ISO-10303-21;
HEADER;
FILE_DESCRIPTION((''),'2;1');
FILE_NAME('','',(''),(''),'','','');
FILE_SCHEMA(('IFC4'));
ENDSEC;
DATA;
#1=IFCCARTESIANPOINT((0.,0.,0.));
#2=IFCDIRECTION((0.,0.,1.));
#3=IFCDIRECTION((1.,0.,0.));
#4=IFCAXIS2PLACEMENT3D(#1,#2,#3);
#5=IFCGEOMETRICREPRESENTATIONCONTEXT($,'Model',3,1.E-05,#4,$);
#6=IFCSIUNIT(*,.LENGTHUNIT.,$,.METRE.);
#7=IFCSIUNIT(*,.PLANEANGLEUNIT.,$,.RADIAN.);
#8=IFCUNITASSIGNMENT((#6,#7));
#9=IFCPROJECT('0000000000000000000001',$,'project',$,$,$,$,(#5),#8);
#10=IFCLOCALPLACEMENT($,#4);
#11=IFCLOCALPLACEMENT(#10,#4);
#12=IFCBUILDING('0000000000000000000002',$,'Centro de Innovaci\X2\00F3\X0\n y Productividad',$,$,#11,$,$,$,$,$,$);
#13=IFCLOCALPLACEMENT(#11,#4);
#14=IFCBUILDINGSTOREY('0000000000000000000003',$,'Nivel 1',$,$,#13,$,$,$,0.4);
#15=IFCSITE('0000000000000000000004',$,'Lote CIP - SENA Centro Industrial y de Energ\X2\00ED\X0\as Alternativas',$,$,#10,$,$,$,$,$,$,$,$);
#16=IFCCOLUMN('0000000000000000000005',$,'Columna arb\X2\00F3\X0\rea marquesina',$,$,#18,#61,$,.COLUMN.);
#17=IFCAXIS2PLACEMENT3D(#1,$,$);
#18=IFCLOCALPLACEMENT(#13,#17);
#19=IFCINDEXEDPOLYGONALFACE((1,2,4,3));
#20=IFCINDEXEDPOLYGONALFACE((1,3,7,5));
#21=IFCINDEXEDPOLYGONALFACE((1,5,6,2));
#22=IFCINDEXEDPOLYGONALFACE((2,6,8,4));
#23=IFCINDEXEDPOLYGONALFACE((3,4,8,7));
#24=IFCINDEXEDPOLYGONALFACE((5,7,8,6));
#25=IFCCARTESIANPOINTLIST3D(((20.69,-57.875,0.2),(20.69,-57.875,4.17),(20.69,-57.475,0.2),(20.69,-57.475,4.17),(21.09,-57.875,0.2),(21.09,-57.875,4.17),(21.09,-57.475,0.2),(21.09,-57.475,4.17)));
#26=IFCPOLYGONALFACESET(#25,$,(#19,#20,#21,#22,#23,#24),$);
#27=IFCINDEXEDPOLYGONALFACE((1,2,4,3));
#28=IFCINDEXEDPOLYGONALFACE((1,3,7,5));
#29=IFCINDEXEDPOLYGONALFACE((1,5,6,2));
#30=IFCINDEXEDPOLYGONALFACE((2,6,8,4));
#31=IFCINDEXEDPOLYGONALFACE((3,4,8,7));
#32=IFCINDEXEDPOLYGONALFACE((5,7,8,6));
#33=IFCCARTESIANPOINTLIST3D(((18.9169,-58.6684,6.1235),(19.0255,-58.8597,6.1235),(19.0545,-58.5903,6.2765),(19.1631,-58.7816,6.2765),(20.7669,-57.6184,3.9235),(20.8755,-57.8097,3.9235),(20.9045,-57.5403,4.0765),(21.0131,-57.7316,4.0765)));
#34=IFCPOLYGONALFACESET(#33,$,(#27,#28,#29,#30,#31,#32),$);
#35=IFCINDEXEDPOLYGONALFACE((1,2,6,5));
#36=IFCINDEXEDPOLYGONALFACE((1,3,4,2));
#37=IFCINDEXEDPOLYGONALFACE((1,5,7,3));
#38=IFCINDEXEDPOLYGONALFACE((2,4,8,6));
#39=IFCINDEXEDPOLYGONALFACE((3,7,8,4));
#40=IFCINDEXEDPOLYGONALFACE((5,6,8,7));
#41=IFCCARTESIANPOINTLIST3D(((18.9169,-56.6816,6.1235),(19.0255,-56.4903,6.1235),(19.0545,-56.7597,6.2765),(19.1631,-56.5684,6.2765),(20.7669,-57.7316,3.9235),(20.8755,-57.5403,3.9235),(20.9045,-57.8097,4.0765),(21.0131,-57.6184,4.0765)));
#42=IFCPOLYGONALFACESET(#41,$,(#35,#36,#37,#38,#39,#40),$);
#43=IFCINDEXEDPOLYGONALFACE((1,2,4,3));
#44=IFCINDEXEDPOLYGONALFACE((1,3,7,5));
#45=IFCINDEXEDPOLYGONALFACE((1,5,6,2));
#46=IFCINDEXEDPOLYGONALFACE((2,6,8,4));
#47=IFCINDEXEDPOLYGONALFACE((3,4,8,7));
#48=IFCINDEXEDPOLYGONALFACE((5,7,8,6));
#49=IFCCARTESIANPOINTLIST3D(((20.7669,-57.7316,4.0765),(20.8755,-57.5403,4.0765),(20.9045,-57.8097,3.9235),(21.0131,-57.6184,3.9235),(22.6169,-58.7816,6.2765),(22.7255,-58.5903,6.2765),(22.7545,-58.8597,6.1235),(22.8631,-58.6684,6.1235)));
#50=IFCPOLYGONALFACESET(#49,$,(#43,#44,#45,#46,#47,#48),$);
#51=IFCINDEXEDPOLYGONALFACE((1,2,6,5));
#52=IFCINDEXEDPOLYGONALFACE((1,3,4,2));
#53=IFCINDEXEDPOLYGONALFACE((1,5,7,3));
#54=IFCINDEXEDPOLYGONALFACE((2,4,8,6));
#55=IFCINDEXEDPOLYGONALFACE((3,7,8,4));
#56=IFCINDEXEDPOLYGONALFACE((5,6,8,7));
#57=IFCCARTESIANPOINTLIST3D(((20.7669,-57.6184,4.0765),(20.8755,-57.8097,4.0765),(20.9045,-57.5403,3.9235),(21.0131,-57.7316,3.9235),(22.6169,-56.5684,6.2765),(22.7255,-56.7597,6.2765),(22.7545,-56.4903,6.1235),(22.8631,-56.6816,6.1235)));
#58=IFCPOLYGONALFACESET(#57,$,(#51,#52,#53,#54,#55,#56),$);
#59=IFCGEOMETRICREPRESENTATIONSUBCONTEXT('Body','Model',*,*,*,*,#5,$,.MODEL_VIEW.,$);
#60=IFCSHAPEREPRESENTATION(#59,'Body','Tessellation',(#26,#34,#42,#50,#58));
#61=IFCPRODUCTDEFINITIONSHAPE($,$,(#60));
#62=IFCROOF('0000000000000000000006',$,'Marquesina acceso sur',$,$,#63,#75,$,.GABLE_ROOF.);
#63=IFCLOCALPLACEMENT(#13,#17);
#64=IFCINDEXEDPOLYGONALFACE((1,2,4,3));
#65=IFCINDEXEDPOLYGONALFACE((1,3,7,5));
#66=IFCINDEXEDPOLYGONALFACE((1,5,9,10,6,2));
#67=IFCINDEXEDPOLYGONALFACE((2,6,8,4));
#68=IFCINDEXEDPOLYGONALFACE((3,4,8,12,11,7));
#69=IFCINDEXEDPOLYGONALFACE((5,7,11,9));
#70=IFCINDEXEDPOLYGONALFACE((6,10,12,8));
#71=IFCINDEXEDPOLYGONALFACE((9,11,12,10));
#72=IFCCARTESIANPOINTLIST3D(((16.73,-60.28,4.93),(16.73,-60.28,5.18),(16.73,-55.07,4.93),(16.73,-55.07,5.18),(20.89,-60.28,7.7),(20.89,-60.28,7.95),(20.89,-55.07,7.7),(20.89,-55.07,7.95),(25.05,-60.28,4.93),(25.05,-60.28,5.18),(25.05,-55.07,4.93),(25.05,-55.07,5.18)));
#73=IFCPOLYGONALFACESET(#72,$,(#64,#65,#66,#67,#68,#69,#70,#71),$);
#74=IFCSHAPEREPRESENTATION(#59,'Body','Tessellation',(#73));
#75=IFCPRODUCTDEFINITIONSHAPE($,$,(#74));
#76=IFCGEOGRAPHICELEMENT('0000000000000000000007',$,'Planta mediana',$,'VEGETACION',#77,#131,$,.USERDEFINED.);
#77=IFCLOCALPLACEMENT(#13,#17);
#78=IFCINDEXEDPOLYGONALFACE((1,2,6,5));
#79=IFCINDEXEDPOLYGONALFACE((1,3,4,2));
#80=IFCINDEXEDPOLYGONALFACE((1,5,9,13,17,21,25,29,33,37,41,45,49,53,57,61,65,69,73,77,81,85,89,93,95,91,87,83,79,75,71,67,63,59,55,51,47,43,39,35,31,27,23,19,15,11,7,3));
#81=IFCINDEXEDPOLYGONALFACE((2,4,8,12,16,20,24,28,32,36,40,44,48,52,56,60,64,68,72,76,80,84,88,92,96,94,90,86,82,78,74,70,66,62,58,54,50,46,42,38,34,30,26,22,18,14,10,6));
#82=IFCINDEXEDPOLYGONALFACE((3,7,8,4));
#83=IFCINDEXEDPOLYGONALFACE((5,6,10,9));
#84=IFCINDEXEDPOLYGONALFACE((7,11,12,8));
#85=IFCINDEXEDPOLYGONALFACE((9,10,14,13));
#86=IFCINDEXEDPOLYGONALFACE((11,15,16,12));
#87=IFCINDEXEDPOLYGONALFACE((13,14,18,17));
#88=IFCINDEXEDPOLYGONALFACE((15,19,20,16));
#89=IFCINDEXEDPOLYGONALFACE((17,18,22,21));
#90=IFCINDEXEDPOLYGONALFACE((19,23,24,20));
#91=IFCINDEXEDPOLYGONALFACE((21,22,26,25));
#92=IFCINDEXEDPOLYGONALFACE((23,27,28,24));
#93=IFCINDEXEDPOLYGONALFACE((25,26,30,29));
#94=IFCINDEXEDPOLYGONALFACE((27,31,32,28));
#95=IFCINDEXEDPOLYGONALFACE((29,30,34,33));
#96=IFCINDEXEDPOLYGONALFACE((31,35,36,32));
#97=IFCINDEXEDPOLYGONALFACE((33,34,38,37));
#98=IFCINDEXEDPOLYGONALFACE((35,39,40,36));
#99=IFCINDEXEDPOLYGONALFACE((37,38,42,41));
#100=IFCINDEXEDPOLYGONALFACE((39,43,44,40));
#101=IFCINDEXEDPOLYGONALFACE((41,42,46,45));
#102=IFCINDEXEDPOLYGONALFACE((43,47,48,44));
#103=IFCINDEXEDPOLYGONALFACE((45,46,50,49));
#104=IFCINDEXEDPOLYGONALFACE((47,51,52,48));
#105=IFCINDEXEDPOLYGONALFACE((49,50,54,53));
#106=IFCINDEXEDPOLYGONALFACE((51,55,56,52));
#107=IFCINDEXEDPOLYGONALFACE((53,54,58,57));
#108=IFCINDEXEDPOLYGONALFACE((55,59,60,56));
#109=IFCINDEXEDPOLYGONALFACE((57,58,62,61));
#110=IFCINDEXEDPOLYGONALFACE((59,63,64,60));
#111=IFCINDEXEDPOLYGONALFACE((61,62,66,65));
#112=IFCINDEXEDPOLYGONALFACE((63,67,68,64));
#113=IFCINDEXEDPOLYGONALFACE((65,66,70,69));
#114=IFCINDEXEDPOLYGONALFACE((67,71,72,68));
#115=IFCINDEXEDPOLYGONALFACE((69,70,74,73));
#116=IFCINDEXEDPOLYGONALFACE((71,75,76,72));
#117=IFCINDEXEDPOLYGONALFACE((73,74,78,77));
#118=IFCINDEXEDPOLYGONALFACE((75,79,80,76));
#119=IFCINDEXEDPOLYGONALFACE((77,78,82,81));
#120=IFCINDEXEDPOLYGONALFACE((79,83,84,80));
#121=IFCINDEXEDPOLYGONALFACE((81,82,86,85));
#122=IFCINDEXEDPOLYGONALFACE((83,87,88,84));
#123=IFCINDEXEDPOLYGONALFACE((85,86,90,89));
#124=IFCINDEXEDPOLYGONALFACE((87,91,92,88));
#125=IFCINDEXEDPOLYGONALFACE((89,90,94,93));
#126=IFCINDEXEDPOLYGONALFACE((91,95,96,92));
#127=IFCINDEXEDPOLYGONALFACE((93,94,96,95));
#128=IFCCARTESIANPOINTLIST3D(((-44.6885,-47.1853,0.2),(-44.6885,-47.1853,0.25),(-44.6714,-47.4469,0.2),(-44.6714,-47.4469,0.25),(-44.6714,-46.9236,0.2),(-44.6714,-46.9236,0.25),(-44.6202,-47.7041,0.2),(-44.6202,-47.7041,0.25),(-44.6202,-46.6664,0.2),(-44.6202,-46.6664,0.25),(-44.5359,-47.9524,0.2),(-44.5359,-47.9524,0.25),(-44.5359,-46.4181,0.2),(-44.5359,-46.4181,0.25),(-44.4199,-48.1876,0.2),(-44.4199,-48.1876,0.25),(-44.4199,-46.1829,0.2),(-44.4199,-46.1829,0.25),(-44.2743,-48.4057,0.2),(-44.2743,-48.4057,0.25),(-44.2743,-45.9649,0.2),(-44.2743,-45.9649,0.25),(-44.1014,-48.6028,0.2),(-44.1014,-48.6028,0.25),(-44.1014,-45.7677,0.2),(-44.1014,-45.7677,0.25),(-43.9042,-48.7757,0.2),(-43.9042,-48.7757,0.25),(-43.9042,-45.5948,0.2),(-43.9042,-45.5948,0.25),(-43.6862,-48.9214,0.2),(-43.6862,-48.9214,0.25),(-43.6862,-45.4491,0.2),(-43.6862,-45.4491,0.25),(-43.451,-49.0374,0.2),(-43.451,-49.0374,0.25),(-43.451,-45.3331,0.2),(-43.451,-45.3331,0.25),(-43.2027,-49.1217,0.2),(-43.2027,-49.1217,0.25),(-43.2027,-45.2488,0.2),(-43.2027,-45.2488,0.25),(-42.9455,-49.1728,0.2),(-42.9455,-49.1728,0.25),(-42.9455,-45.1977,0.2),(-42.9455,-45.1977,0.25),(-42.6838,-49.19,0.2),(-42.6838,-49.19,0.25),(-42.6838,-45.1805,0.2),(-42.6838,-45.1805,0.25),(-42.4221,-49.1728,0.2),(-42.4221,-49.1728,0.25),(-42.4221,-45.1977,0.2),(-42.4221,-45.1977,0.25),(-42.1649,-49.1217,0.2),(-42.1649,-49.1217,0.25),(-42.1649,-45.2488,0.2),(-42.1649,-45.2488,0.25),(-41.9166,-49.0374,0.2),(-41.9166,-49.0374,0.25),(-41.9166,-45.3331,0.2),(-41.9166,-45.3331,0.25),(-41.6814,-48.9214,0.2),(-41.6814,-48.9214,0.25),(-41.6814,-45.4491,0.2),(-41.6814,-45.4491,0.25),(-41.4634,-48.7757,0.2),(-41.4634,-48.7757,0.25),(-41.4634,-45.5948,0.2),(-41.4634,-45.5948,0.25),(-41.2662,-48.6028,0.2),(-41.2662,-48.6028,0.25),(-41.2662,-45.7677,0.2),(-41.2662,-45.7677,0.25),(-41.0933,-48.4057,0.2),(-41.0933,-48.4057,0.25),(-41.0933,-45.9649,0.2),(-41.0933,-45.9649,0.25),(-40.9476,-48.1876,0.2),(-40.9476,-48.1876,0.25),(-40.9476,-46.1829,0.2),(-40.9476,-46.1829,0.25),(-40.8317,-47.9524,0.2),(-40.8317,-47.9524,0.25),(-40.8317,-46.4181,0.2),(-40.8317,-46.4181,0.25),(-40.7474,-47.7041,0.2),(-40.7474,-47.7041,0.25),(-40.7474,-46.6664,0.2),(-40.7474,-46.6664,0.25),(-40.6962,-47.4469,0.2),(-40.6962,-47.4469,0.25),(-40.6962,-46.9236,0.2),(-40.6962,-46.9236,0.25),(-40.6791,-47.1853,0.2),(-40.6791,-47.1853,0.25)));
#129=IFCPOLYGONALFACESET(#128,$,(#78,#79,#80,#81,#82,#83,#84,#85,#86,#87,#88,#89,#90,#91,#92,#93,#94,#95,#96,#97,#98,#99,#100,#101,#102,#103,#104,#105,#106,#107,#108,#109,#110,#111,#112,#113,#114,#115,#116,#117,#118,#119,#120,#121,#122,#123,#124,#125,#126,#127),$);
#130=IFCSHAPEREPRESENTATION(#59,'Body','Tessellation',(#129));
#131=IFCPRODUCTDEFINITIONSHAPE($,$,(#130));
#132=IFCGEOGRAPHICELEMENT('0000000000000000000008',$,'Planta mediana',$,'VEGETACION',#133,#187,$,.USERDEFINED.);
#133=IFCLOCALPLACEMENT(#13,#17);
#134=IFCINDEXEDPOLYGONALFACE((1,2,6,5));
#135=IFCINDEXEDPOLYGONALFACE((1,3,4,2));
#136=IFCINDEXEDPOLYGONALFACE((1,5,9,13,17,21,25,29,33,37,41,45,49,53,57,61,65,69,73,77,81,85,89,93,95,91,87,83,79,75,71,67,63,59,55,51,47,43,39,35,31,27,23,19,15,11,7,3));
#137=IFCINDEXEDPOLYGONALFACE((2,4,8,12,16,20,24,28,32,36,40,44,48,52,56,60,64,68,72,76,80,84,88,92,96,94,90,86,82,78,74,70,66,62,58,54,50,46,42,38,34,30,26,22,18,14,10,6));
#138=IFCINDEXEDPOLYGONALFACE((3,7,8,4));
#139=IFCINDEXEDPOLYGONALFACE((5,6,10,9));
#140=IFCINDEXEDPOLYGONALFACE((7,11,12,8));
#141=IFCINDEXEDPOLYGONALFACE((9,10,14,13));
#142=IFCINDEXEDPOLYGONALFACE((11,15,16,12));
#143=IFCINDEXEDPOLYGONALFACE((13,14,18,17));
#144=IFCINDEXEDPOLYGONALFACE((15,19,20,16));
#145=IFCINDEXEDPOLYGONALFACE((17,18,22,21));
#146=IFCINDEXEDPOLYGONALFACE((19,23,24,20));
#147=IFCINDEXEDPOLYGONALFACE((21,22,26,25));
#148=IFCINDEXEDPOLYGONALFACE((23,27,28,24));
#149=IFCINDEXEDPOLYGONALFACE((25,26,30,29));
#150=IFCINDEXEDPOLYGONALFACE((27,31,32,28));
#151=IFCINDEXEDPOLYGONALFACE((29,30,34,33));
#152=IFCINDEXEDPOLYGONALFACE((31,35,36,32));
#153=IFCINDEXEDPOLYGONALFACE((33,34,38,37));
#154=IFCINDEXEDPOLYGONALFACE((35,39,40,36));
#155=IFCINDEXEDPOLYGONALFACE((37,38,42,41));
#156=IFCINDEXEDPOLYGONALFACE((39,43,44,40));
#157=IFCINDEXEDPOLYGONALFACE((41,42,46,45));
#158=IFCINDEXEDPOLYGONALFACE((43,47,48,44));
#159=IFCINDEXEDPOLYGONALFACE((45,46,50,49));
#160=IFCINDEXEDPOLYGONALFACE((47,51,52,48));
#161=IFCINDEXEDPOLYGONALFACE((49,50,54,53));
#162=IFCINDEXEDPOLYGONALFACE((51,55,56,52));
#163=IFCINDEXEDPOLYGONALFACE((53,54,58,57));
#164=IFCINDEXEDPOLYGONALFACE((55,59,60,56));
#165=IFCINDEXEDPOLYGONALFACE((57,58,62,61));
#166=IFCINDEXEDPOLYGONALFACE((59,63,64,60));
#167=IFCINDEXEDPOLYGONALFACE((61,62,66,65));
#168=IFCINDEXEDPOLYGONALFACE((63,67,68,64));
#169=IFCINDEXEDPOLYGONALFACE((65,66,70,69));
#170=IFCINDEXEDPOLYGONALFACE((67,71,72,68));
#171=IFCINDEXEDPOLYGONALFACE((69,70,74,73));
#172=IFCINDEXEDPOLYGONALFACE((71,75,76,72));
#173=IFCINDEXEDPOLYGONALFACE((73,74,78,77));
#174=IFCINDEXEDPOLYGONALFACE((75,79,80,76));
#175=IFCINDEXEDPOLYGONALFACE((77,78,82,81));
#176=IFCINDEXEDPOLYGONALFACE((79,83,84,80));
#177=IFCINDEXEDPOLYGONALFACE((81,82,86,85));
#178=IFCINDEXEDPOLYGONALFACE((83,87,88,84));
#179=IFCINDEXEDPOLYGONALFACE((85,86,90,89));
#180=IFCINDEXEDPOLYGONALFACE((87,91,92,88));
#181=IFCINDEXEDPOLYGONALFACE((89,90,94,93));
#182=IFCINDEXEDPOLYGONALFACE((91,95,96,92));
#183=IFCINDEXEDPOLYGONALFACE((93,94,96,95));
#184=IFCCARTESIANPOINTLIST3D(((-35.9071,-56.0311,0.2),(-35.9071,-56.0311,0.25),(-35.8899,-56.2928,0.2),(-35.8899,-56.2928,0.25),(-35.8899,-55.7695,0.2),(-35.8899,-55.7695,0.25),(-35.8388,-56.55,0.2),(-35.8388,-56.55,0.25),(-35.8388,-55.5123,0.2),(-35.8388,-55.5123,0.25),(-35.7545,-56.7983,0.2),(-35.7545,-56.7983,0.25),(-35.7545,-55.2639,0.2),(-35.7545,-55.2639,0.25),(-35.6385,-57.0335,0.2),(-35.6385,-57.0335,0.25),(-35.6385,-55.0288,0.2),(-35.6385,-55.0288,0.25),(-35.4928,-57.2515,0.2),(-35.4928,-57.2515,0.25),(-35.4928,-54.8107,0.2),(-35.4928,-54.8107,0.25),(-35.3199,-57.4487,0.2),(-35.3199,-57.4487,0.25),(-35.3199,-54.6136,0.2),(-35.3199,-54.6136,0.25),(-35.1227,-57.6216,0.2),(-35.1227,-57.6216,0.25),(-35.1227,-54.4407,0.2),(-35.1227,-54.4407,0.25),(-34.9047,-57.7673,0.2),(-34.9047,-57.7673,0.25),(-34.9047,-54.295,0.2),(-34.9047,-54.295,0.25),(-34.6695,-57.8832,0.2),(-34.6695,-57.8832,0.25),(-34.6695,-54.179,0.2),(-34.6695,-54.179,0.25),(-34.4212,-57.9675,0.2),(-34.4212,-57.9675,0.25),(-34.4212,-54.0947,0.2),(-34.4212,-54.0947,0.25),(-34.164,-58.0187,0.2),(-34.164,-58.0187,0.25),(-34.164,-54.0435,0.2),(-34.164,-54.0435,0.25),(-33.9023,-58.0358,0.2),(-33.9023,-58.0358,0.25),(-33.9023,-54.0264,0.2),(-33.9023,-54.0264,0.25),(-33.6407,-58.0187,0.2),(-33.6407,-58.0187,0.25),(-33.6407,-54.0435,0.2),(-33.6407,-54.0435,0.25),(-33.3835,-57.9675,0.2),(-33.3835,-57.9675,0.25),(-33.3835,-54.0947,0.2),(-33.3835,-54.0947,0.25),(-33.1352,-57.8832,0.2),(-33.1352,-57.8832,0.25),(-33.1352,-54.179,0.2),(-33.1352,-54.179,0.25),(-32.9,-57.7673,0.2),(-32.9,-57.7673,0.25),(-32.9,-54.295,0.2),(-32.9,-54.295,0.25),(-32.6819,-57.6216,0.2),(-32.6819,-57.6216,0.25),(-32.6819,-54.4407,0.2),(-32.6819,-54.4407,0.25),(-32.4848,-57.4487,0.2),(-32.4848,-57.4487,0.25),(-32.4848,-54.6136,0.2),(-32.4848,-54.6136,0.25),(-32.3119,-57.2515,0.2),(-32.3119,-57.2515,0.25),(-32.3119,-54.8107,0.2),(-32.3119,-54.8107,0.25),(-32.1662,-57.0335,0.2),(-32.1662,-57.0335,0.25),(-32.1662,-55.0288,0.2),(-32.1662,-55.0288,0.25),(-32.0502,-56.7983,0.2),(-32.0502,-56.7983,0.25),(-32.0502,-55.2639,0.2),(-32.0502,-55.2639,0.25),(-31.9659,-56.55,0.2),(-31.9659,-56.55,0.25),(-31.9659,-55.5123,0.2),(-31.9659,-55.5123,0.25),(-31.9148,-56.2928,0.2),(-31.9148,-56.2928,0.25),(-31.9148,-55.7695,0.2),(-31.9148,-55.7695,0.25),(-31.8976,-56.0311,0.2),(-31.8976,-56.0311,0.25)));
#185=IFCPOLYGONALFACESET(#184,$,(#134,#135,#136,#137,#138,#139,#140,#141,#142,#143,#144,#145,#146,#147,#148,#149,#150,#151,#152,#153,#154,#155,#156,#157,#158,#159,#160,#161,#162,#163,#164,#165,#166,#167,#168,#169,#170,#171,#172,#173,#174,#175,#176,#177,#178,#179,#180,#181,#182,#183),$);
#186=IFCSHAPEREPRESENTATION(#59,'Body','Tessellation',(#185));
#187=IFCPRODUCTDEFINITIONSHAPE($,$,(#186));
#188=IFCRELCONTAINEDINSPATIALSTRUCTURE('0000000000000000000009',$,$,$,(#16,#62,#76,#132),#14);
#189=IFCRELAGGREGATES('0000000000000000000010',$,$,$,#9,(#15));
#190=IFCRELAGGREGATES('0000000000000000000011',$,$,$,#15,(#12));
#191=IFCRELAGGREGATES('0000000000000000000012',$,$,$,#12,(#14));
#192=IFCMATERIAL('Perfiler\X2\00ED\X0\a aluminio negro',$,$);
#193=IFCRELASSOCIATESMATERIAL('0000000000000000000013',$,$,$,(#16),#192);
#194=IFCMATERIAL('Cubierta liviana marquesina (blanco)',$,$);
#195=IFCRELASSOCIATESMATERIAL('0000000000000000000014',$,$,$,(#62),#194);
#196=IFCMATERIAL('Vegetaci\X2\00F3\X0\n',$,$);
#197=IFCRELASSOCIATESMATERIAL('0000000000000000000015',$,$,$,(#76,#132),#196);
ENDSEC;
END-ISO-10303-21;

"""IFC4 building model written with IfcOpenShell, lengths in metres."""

from ifc_helpers import new_model, si_unit, frame, origin_with_axes, place, context, subcontext, project, spatial, polyline, rectangle, outline, extrude, material, element, save


model = new_model("IFC4")

# Units and contexts
model_context = context("Model", 3, precision=1e-05, world=origin_with_axes())
body_context = subcontext(model_context, "Body", "Model", "MODEL_VIEW")
ifc_project = project(units=[si_unit("LENGTHUNIT", "METRE"), si_unit("PLANEANGLEUNIT", "RADIAN")], contexts=[model_context])

# Site, building, storey
site_placement = place(None, origin_with_axes())
site = spatial("IfcSite", under=ifc_project, at=site_placement, Name="Lote CIP - SENA Centro Industrial y de Energías Alternativas")
building_placement = place(site_placement, origin_with_axes())
building = spatial("IfcBuilding", under=site, at=building_placement, Name="Centro de Innovación y Productividad")
storey_placement = place(building_placement, origin_with_axes())
storey = spatial("IfcBuildingStorey", under=building, at=storey_placement, Name="Nivel 1", Elevation=0.4)

# Column
ifc_material_1 = material(Name="Perfilería aluminio negro")
column_placement = place(storey_placement, origin_with_axes())
element("IfcColumn", 1, at=column_placement, inside=storey, material=ifc_material_1, Name="Columna arbórea marquesina", PredefinedType="COLUMN", context=body_context, shape_type="SweptSolid", body=[
    extrude(rectangle(XDim=0.4, YDim=0.4), frame((20.89, -57.675, 0.2), z_axis=(0.0, 0.0, 1.0), x_axis=(0.0, -1.0, 0.0)), (0.0, 0.0, 1.0), 3.97),
    extrude(rectangle(XDim=0.22, YDim=0.22), frame((20.89, -57.675, 4.0), z_axis=(-0.60453, -0.343112, 0.718901), x_axis=(0.493606, -0.869686, 0.0)), (0.0, 0.0, 1.0), 3.0602),
    extrude(rectangle(XDim=0.22, YDim=0.22), frame((20.89, -57.675, 4.0), z_axis=(-0.60453, 0.343112, 0.718901), x_axis=(-0.493606, -0.869686, 0.0)), (0.0, 0.0, 1.0), 3.0602),
    extrude(rectangle(XDim=0.22, YDim=0.22), frame((20.89, -57.675, 4.0), z_axis=(0.60453, -0.343112, 0.718901), x_axis=(0.493606, 0.869686, 0.0)), (0.0, 0.0, 1.0), 3.0602),
    extrude(rectangle(XDim=0.22, YDim=0.22), frame((20.89, -57.675, 4.0), z_axis=(0.60453, 0.343112, 0.718901), x_axis=(-0.493606, 0.869686, 0.0)), (0.0, 0.0, 1.0), 3.0602),
])

# Roof
ifc_material_2 = material(Name="Cubierta liviana marquesina (blanco)")
roof_placement = place(storey_placement, origin_with_axes())
element("IfcRoof", 2, at=roof_placement, inside=storey, material=ifc_material_2, Name="Marquesina acceso sur", PredefinedType="GABLE_ROOF", context=body_context, shape_type="SweptSolid", body=[
    extrude(outline(polyline([(16.73, 4.93), (20.89, 7.7), (25.05, 4.93), (25.05, 5.18), (20.89, 7.95), (16.73, 5.18), (16.73, 4.93)])), frame((0.0, -55.07, 0.0), z_axis=(0.0, -1.0, 0.0), x_axis=(1.0, 0.0, 0.0)), (0.0, 0.0, 1.0), 5.21),
])

# Geographic elements
ifc_material_3 = material(Name="Vegetación")
geographic_element_1_placement = place(storey_placement, origin_with_axes())
element("IfcGeographicElement", 3, at=geographic_element_1_placement, inside=storey, material=ifc_material_3, Name="Planta mediana", ObjectType="VEGETACION", PredefinedType="USERDEFINED", context=body_context, shape_type="SweptSolid", body=[
    extrude(outline(polyline([(-40.6791, -47.1853), (-40.6962, -47.4469), (-40.7474, -47.7041), (-40.8317, -47.9524), (-40.9476, -48.1876), (-41.0933, -48.4057), (-41.2662, -48.6028), (-41.4634, -48.7757), (-41.6814, -48.9214), (-41.9166, -49.0374), (-42.1649, -49.1217), (-42.4221, -49.1728), (-42.6838, -49.19), (-42.9455, -49.1728), (-43.2027, -49.1217), (-43.451, -49.0374), (-43.6862, -48.9214), (-43.9042, -48.7757), (-44.1014, -48.6028), (-44.2743, -48.4057), (-44.4199, -48.1876), (-44.5359, -47.9524), (-44.6202, -47.7041), (-44.6714, -47.4469), (-44.6885, -47.1853), (-44.6714, -46.9236), (-44.6202, -46.6664), (-44.5359, -46.4181), (-44.4199, -46.1829), (-44.2743, -45.9649), (-44.1014, -45.7677), (-43.9042, -45.5948), (-43.6862, -45.4491), (-43.451, -45.3331), (-43.2027, -45.2488), (-42.9455, -45.1977), (-42.6838, -45.1805), (-42.4221, -45.1977), (-42.1649, -45.2488), (-41.9166, -45.3331), (-41.6814, -45.4491), (-41.4634, -45.5948), (-41.2662, -45.7677), (-41.0933, -45.9649), (-40.9476, -46.1829), (-40.8317, -46.4181), (-40.7474, -46.6664), (-40.6962, -46.9236), (-40.6791, -47.1853)])), frame((0.0, 0.0, 0.2)), (0.0, 0.0, 1.0), 0.05),
])
geographic_element_2_placement = place(storey_placement, origin_with_axes())
element("IfcGeographicElement", 4, at=geographic_element_2_placement, inside=storey, material=ifc_material_3, Name="Planta mediana", ObjectType="VEGETACION", PredefinedType="USERDEFINED", context=body_context, shape_type="SweptSolid", body=[
    extrude(outline(polyline([(-31.8976, -56.0311), (-31.9148, -56.2928), (-31.9659, -56.55), (-32.0502, -56.7983), (-32.1662, -57.0335), (-32.3119, -57.2515), (-32.4848, -57.4487), (-32.6819, -57.6216), (-32.9, -57.7673), (-33.1352, -57.8832), (-33.3835, -57.9675), (-33.6407, -58.0187), (-33.9023, -58.0358), (-34.164, -58.0187), (-34.4212, -57.9675), (-34.6695, -57.8832), (-34.9047, -57.7673), (-35.1227, -57.6216), (-35.3199, -57.4487), (-35.4928, -57.2515), (-35.6385, -57.0335), (-35.7545, -56.7983), (-35.8388, -56.55), (-35.8899, -56.2928), (-35.9071, -56.0311), (-35.8899, -55.7695), (-35.8388, -55.5123), (-35.7545, -55.2639), (-35.6385, -55.0288), (-35.4928, -54.8107), (-35.3199, -54.6136), (-35.1227, -54.4407), (-34.9047, -54.295), (-34.6695, -54.179), (-34.4212, -54.0947), (-34.164, -54.0435), (-33.9023, -54.0264), (-33.6407, -54.0435), (-33.3835, -54.0947), (-33.1352, -54.179), (-32.9, -54.295), (-32.6819, -54.4407), (-32.4848, -54.6136), (-32.3119, -54.8107), (-32.1662, -55.0288), (-32.0502, -55.2639), (-31.9659, -55.5123), (-31.9148, -55.7695), (-31.8976, -56.0311)])), frame((0.0, 0.0, 0.2)), (0.0, 0.0, 1.0), 0.05),
])

save(model, "model.ifc")
